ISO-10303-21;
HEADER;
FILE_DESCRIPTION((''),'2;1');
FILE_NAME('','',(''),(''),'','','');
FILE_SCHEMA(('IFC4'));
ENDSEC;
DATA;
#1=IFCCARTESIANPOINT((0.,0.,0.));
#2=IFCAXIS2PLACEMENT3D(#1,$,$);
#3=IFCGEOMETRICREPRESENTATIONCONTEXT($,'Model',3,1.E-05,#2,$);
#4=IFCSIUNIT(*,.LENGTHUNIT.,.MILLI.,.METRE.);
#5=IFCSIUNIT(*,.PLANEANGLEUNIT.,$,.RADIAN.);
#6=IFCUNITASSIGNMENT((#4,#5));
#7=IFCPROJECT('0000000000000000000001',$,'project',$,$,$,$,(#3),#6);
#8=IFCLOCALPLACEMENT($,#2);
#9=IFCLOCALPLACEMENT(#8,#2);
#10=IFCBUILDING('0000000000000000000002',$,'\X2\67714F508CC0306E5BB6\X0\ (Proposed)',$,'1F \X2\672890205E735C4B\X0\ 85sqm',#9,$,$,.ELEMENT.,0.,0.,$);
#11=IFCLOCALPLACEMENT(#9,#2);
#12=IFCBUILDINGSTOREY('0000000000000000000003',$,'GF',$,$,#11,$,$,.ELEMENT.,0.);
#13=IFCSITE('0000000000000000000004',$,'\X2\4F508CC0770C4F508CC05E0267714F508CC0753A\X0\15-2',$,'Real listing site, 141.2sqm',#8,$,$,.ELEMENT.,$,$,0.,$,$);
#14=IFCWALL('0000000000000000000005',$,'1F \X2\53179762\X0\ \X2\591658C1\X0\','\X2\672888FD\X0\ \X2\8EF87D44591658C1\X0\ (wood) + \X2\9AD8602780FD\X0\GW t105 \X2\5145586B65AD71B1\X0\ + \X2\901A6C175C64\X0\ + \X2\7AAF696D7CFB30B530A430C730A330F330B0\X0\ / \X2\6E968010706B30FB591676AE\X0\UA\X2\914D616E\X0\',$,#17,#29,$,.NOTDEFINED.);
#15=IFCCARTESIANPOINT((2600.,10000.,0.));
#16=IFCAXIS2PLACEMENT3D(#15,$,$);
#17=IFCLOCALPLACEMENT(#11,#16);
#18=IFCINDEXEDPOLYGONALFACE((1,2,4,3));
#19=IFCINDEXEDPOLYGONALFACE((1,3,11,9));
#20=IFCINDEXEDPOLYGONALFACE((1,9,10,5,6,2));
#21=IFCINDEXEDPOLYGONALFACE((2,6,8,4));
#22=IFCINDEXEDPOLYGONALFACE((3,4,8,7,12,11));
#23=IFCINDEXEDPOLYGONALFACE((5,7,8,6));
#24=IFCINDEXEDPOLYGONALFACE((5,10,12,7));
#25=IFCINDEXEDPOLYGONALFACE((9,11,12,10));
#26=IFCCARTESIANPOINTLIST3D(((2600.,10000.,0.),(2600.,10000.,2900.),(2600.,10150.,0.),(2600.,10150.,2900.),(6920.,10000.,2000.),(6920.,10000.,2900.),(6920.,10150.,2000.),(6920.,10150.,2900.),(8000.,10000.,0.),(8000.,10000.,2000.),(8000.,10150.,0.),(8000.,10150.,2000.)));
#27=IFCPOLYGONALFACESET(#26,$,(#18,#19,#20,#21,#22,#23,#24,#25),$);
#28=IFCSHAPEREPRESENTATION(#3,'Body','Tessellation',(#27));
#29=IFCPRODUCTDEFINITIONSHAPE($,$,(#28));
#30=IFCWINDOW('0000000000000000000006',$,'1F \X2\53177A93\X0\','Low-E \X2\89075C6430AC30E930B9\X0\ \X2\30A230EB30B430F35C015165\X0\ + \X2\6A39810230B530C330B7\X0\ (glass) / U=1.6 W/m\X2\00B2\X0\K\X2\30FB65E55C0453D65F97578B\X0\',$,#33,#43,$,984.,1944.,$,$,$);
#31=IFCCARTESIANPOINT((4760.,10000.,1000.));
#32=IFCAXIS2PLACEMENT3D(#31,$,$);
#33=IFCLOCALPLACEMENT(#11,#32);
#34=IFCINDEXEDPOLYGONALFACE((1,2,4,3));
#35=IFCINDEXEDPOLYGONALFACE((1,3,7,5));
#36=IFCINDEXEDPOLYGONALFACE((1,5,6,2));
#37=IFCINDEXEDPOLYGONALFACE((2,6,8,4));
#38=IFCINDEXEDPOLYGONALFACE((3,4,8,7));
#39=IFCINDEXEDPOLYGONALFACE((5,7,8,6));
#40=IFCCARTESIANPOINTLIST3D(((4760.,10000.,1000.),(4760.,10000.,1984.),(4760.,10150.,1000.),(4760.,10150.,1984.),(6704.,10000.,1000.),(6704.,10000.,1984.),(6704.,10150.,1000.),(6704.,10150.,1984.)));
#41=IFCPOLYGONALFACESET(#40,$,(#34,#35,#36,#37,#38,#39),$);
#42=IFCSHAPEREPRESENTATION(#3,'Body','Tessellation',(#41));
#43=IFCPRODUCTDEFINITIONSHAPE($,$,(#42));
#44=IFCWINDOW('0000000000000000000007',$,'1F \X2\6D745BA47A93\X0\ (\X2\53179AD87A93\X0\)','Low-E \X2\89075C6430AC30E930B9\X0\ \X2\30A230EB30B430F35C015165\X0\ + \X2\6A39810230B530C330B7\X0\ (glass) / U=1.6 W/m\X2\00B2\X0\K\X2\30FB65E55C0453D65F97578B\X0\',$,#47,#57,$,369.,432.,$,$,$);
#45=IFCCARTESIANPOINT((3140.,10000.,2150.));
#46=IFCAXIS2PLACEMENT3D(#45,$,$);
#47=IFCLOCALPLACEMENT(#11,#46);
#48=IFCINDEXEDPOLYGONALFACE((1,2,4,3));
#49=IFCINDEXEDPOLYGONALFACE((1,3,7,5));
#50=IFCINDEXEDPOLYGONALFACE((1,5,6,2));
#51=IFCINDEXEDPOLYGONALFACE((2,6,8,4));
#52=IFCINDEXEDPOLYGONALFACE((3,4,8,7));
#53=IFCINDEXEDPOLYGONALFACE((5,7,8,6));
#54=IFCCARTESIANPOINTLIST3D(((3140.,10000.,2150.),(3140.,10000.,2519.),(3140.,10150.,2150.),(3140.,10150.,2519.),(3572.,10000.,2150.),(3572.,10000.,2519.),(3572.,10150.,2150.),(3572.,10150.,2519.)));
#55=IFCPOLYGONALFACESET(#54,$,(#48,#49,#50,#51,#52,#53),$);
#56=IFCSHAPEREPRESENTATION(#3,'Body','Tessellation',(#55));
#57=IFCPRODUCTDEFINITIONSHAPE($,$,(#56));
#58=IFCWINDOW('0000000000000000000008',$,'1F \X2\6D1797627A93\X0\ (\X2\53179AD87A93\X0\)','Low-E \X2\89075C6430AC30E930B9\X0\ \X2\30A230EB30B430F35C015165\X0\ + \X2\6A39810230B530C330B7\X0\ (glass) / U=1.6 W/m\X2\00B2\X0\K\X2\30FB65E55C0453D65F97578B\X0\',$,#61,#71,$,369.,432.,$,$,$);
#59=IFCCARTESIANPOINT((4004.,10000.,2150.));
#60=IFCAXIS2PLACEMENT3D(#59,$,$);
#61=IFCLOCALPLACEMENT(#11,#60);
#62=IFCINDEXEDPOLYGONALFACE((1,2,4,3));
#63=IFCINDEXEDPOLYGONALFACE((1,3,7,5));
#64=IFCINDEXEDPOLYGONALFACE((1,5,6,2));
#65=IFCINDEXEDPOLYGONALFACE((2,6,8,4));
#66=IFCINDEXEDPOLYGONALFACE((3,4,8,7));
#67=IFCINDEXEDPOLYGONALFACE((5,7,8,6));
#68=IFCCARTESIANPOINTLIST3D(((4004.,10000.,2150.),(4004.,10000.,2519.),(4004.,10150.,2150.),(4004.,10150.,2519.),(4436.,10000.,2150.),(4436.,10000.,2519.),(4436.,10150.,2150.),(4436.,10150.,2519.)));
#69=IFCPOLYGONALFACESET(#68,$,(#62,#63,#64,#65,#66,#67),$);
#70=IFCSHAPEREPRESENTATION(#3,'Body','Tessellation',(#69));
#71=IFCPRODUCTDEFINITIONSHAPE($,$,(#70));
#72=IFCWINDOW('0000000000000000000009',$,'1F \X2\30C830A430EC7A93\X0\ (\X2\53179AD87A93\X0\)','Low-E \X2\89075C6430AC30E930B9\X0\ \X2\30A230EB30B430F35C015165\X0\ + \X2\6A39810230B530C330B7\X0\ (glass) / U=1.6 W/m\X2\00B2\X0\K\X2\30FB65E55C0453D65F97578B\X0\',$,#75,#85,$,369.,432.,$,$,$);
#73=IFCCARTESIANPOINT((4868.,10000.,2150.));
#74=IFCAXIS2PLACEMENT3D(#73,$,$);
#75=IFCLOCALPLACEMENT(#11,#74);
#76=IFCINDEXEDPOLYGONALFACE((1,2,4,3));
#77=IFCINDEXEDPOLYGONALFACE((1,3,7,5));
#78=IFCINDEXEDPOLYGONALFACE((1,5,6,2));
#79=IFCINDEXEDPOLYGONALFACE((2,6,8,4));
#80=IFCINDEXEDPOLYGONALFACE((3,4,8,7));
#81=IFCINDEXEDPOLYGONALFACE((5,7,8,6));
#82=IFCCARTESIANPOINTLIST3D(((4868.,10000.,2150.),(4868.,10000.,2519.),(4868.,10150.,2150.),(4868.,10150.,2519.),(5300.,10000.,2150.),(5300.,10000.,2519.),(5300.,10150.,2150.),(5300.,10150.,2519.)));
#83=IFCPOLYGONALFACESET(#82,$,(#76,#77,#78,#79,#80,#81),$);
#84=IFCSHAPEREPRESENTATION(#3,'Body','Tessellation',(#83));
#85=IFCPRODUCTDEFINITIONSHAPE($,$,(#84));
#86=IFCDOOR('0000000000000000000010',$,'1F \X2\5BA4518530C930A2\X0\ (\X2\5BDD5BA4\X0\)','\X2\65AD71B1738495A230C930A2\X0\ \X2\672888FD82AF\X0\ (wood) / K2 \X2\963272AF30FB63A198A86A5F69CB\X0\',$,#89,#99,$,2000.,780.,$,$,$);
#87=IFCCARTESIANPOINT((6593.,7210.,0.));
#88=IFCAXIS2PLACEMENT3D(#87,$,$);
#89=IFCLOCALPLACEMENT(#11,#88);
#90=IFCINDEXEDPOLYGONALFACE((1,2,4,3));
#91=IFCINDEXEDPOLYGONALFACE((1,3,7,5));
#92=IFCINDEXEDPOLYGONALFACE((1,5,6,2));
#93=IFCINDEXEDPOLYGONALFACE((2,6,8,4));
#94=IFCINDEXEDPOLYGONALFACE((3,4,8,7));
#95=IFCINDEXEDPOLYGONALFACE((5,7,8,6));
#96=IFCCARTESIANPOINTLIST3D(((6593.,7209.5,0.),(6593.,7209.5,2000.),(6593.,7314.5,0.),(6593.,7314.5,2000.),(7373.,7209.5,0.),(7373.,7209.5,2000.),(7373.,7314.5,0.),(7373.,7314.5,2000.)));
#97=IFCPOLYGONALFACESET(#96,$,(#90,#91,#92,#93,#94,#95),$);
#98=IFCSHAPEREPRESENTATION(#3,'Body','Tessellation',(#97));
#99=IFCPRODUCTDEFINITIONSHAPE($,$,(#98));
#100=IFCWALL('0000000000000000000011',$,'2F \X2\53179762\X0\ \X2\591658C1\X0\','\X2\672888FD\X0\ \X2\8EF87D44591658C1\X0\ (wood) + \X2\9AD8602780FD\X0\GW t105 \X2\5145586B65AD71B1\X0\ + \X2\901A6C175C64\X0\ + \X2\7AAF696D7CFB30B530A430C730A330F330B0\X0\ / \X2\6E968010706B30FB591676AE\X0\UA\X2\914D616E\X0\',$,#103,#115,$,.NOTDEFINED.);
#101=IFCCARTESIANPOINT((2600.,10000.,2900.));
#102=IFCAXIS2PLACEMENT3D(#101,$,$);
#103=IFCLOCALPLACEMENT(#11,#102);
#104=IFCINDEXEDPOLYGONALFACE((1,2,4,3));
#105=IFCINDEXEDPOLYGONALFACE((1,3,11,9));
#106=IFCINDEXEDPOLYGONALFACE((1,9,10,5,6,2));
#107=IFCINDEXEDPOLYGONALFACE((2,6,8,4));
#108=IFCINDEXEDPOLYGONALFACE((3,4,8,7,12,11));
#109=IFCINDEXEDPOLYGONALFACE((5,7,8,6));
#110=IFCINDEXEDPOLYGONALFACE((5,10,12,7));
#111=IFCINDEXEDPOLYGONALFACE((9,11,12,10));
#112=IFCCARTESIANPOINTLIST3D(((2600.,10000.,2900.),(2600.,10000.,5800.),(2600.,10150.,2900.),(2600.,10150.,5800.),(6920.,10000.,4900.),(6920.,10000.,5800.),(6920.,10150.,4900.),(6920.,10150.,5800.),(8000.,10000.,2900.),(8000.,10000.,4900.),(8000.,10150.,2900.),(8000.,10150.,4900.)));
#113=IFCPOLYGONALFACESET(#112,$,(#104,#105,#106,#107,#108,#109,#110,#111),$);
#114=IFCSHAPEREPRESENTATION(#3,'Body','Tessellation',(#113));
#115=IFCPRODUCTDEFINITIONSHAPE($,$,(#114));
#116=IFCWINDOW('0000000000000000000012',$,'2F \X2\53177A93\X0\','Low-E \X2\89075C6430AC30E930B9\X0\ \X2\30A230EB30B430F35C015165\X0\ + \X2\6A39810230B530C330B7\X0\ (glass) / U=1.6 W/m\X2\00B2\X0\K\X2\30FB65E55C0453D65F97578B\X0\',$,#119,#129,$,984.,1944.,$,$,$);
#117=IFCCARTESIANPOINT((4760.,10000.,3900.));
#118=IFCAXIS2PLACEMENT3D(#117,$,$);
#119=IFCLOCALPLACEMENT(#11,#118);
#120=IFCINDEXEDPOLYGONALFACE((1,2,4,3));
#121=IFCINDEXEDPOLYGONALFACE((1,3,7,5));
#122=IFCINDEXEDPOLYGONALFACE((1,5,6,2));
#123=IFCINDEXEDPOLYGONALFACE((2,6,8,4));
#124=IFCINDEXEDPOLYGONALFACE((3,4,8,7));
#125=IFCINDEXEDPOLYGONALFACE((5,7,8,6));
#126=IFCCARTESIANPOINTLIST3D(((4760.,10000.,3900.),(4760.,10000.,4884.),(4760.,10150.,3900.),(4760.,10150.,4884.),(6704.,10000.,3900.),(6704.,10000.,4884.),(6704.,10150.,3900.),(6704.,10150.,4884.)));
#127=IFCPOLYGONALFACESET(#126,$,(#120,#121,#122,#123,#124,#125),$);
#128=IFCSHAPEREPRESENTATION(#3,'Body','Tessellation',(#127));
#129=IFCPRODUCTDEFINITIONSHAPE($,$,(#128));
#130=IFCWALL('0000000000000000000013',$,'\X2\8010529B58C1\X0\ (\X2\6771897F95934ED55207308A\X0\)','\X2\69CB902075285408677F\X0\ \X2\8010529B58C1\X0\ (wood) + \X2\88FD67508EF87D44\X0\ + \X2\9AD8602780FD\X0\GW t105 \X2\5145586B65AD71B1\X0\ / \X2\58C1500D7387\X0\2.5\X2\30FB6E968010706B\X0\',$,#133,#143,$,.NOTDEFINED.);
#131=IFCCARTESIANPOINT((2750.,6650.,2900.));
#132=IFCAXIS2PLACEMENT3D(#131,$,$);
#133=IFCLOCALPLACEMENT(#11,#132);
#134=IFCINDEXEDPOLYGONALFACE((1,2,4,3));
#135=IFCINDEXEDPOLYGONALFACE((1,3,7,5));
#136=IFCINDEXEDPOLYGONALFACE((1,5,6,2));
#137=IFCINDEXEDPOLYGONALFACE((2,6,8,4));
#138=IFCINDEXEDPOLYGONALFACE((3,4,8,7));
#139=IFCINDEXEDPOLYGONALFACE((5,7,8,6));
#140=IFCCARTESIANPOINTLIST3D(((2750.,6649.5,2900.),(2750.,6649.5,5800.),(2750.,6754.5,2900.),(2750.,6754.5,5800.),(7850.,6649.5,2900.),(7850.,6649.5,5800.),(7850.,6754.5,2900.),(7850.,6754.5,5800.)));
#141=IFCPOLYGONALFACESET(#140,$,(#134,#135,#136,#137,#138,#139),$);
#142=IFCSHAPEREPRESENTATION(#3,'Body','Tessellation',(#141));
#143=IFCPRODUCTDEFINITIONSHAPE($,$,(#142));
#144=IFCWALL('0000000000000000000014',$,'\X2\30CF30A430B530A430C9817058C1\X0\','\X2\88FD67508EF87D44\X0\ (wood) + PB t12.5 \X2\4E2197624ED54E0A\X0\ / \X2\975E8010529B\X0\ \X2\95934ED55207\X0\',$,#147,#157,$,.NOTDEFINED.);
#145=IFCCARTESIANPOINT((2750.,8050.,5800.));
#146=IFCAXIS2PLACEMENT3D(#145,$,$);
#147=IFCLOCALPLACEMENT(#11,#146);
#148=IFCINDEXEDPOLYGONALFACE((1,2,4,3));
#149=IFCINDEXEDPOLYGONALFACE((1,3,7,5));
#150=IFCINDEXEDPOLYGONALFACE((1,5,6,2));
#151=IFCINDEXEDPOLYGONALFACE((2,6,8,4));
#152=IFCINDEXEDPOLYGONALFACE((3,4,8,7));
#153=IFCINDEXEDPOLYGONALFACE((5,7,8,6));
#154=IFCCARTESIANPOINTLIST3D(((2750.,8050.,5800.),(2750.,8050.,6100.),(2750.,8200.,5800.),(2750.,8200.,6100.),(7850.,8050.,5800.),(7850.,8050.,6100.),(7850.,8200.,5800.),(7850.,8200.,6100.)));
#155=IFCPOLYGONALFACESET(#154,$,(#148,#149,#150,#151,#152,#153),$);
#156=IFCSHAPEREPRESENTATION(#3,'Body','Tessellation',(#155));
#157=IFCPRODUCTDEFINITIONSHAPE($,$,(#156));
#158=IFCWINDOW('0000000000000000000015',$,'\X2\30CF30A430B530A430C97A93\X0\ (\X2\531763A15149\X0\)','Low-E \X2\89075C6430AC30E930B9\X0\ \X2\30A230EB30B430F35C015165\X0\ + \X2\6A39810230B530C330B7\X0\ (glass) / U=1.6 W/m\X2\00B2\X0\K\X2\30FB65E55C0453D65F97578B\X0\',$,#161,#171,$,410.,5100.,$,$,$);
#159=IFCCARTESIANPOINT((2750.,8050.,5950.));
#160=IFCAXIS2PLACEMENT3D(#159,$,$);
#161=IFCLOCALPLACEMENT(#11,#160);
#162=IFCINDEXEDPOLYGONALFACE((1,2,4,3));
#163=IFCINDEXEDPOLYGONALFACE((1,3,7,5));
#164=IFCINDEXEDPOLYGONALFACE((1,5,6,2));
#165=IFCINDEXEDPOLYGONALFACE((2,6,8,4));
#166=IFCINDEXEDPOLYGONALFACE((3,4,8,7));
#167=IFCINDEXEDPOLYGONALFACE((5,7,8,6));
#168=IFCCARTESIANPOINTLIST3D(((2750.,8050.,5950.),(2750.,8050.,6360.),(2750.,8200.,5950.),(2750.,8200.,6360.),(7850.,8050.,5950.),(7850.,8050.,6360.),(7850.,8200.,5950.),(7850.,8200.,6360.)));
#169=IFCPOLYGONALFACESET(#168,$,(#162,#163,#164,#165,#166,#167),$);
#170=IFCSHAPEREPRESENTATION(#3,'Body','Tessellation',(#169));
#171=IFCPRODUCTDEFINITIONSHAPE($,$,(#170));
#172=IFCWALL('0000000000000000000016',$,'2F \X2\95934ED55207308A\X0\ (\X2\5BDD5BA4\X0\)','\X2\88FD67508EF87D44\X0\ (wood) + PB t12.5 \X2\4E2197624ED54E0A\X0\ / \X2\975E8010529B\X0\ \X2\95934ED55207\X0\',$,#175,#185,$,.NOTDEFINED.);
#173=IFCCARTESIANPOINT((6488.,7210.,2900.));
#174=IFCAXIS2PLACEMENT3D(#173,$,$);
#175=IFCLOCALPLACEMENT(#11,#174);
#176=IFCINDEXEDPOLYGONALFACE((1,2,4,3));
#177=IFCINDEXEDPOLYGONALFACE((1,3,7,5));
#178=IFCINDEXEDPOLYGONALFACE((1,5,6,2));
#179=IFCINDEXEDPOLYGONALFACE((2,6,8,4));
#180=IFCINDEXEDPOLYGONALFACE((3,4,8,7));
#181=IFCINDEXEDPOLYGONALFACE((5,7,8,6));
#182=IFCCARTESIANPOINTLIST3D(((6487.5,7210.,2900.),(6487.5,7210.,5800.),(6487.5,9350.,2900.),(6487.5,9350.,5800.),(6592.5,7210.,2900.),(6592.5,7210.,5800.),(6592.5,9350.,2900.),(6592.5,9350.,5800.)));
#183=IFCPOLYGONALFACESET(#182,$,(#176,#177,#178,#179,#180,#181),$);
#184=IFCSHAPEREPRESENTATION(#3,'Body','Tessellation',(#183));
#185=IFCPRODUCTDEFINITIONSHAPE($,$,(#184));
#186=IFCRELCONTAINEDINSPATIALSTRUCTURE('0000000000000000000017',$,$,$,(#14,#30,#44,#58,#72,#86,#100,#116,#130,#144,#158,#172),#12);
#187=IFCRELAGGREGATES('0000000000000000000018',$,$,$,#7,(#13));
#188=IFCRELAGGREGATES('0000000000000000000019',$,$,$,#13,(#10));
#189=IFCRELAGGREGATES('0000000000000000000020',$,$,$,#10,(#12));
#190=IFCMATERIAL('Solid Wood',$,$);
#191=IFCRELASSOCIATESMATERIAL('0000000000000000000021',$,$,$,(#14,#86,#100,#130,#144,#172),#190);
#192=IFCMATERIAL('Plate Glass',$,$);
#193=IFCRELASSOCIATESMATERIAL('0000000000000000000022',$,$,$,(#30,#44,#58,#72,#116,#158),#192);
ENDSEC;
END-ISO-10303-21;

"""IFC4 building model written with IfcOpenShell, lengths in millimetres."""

from ifc_helpers import new_model, si_unit, frame, frame_2d, origin, place, context, project, spatial, rectangle, extrude, material, element, fill, save


model = new_model("IFC4")

# Units and contexts
model_context = context("Model", 3, precision=1e-05, world=origin())
ifc_project = project(units=[si_unit("LENGTHUNIT", "METRE", prefix="MILLI"), si_unit("PLANEANGLEUNIT", "RADIAN")], contexts=[model_context])

# Site, building, storey
site_placement = place(None, origin())
site = spatial("IfcSite", under=ifc_project, at=site_placement, Name="佐賀県佐賀市東佐賀町15-2", ObjectType="Real listing site, 141.2sqm", CompositionType="ELEMENT", RefElevation=0.0)
building_placement = place(site_placement, origin())
building = spatial("IfcBuilding", under=site, at=building_placement, Name="東佐賀の家 (Proposed)", ObjectType="1F 木造平屋 85sqm", CompositionType="ELEMENT", ElevationOfRefHeight=0.0, ElevationOfTerrain=0.0)
storey_placement = place(building_placement, origin())
storey = spatial("IfcBuildingStorey", under=building, at=storey_placement, Name="GF", CompositionType="ELEMENT", Elevation=0.0)

# Wall, openings, windows
ifc_material_1 = material(Name="Solid Wood")
wall_1_placement = place(storey_placement, frame((2600.0, 10000.0, 0.0)))
wall_1 = element("IfcWall", 1, at=wall_1_placement, inside=storey, material=ifc_material_1, Name="1F 北面 外壁", Description="木製 軸組外壁 (wood) + 高性能GW t105 充填断熱 + 通気層 + 窯業系サイディング / 準耐火・外皮UA配慮", PredefinedType="NOTDEFINED", context=model_context, shape_type="SweptSolid", body=[
    extrude(rectangle(XDim=5400.0, YDim=150.0, at=frame_2d((2700.0, 75.0))), frame((2600.0, 10000.0, 0.0)), (0.0, 0.0, 1.0), 2900.0),
])
opening_1_placement = place(storey_placement, frame((4760.0, 10000.0, 1000.0)))
opening_1 = element("IfcOpeningElement", 2, at=opening_1_placement, cuts=wall_1, PredefinedType="NOTDEFINED", context=model_context, shape_type="SweptSolid", body=[
    extrude(rectangle(XDim=1944.0, YDim=150.0, at=frame_2d((972.0, 75.0))), frame((4760.0, 10000.0, 1000.0)), (0.0, 0.0, 1.0), 984.0),
])
opening_2_placement = place(storey_placement, frame((3140.0, 10000.0, 2150.0)))
opening_2 = element("IfcOpeningElement", 3, at=opening_2_placement, cuts=wall_1, PredefinedType="NOTDEFINED", context=model_context, shape_type="SweptSolid", body=[
    extrude(rectangle(XDim=432.0, YDim=150.0, at=frame_2d((216.0, 75.0))), frame((3140.0, 10000.0, 2150.0)), (0.0, 0.0, 1.0), 369.0),
])
opening_3_placement = place(storey_placement, frame((4004.0, 10000.0, 2150.0)))
opening_3 = element("IfcOpeningElement", 4, at=opening_3_placement, cuts=wall_1, PredefinedType="NOTDEFINED", context=model_context, shape_type="SweptSolid", body=[
    extrude(rectangle(XDim=432.0, YDim=150.0, at=frame_2d((216.0, 75.0))), frame((4004.0, 10000.0, 2150.0)), (0.0, 0.0, 1.0), 369.0),
])
opening_4_placement = place(storey_placement, frame((4868.0, 10000.0, 2150.0)))
opening_4 = element("IfcOpeningElement", 5, at=opening_4_placement, cuts=wall_1, PredefinedType="NOTDEFINED", context=model_context, shape_type="SweptSolid", body=[
    extrude(rectangle(XDim=432.0, YDim=150.0, at=frame_2d((216.0, 75.0))), frame((4868.0, 10000.0, 2150.0)), (0.0, 0.0, 1.0), 369.0),
])
ifc_material_2 = material(Name="Plate Glass")
window_1_placement = place(storey_placement, frame((4760.0, 10000.0, 1000.0)))
window_1 = element("IfcWindow", 6, at=window_1_placement, inside=storey, material=ifc_material_2, Name="1F 北窓", Description="Low-E 複層ガラス アルゴン封入 + 樹脂サッシ (glass) / U=1.6 W/m²K・日射取得型", OverallHeight=984.0, OverallWidth=1944.0, context=model_context, shape_type="SweptSolid", body=[
    extrude(rectangle(XDim=1944.0, YDim=150.0, at=frame_2d((972.0, 75.0))), frame((4760.0, 10000.0, 1000.0)), (0.0, 0.0, 1.0), 984.0),
])
fill(opening_1, window_1)
window_2_placement = place(storey_placement, frame((3140.0, 10000.0, 2150.0)))
window_2 = element("IfcWindow", 7, at=window_2_placement, inside=storey, material=ifc_material_2, Name="1F 浴室窓 (北高窓)", Description="Low-E 複層ガラス アルゴン封入 + 樹脂サッシ (glass) / U=1.6 W/m²K・日射取得型", OverallHeight=369.0, OverallWidth=432.0, context=model_context, shape_type="SweptSolid", body=[
    extrude(rectangle(XDim=432.0, YDim=150.0, at=frame_2d((216.0, 75.0))), frame((3140.0, 10000.0, 2150.0)), (0.0, 0.0, 1.0), 369.0),
])
fill(opening_2, window_2)
window_3_placement = place(storey_placement, frame((4004.0, 10000.0, 2150.0)))
window_3 = element("IfcWindow", 8, at=window_3_placement, inside=storey, material=ifc_material_2, Name="1F 洗面窓 (北高窓)", Description="Low-E 複層ガラス アルゴン封入 + 樹脂サッシ (glass) / U=1.6 W/m²K・日射取得型", OverallHeight=369.0, OverallWidth=432.0, context=model_context, shape_type="SweptSolid", body=[
    extrude(rectangle(XDim=432.0, YDim=150.0, at=frame_2d((216.0, 75.0))), frame((4004.0, 10000.0, 2150.0)), (0.0, 0.0, 1.0), 369.0),
])
fill(opening_3, window_3)
window_4_placement = place(storey_placement, frame((4868.0, 10000.0, 2150.0)))
window_4 = element("IfcWindow", 9, at=window_4_placement, inside=storey, material=ifc_material_2, Name="1F トイレ窓 (北高窓)", Description="Low-E 複層ガラス アルゴン封入 + 樹脂サッシ (glass) / U=1.6 W/m²K・日射取得型", OverallHeight=369.0, OverallWidth=432.0, context=model_context, shape_type="SweptSolid", body=[
    extrude(rectangle(XDim=432.0, YDim=150.0, at=frame_2d((216.0, 75.0))), frame((4868.0, 10000.0, 2150.0)), (0.0, 0.0, 1.0), 369.0),
])
fill(opening_4, window_4)

# Door
door_1_placement = place(storey_placement, frame((6593.0, 7210.0, 0.0)))
element("IfcDoor", 10, at=door_1_placement, inside=storey, material=ifc_material_1, Name="1F 室内ドア (寝室)", Description="断熱玄関ドア 木製芯 (wood) / K2 防犯・採風機構", OverallHeight=2000.0, OverallWidth=780.0, context=model_context, shape_type="SweptSolid", body=[
    extrude(rectangle(XDim=780.0, YDim=105.0, at=frame_2d((390.0, 52.0))), frame((6593.0, 7210.0, 0.0)), (0.0, 0.0, 1.0), 2000.0),
])

# Wall, opening, window
wall_2_placement = place(storey_placement, frame((2600.0, 10000.0, 2900.0)))
wall_2 = element("IfcWall", 11, at=wall_2_placement, inside=storey, material=ifc_material_1, Name="2F 北面 外壁", Description="木製 軸組外壁 (wood) + 高性能GW t105 充填断熱 + 通気層 + 窯業系サイディング / 準耐火・外皮UA配慮", PredefinedType="NOTDEFINED", context=model_context, shape_type="SweptSolid", body=[
    extrude(rectangle(XDim=5400.0, YDim=150.0, at=frame_2d((2700.0, 75.0))), frame((2600.0, 10000.0, 2900.0)), (0.0, 0.0, 1.0), 2900.0),
])
opening_5_placement = place(storey_placement, frame((4760.0, 10000.0, 3900.0)))
opening_5 = element("IfcOpeningElement", 12, at=opening_5_placement, cuts=wall_2, PredefinedType="NOTDEFINED", context=model_context, shape_type="SweptSolid", body=[
    extrude(rectangle(XDim=1944.0, YDim=150.0, at=frame_2d((972.0, 75.0))), frame((4760.0, 10000.0, 3900.0)), (0.0, 0.0, 1.0), 984.0),
])
window_5_placement = place(storey_placement, frame((4760.0, 10000.0, 3900.0)))
window_5 = element("IfcWindow", 13, at=window_5_placement, inside=storey, material=ifc_material_2, Name="2F 北窓", Description="Low-E 複層ガラス アルゴン封入 + 樹脂サッシ (glass) / U=1.6 W/m²K・日射取得型", OverallHeight=984.0, OverallWidth=1944.0, context=model_context, shape_type="SweptSolid", body=[
    extrude(rectangle(XDim=1944.0, YDim=150.0, at=frame_2d((972.0, 75.0))), frame((4760.0, 10000.0, 3900.0)), (0.0, 0.0, 1.0), 984.0),
])
fill(opening_5, window_5)

# Wall
wall_3_placement = place(storey_placement, frame((2750.0, 6650.0, 2900.0)))
element("IfcWall", 14, at=wall_3_placement, inside=storey, material=ifc_material_1, Name="耐力壁 (東西間仕切り)", Description="構造用合板 耐力壁 (wood) + 製材軸組 + 高性能GW t105 充填断熱 / 壁倍率2.5・準耐火", PredefinedType="NOTDEFINED", context=model_context, shape_type="SweptSolid", body=[
    extrude(rectangle(XDim=5100.0, YDim=105.0, at=frame_2d((2550.0, 52.0))), frame((2750.0, 6650.0, 2900.0)), (0.0, 0.0, 1.0), 2900.0),
])

# Wall, opening, window
wall_4_placement = place(storey_placement, frame((2750.0, 8050.0, 5800.0)))
wall_4 = element("IfcWall", 15, at=wall_4_placement, inside=storey, material=ifc_material_1, Name="ハイサイド腰壁", Description="製材軸組 (wood) + PB t12.5 両面仕上 / 非耐力 間仕切", PredefinedType="NOTDEFINED", context=model_context, shape_type="SweptSolid", body=[
    extrude(rectangle(XDim=5100.0, YDim=150.0, at=frame_2d((2550.0, 75.0))), frame((2750.0, 8050.0, 5800.0)), (0.0, 0.0, 1.0), 700.0),
])
opening_6_placement = place(storey_placement, frame((2750.0, 8050.0, 5950.0)))
opening_6 = element("IfcOpeningElement", 16, at=opening_6_placement, cuts=wall_4, PredefinedType="NOTDEFINED", context=model_context, shape_type="SweptSolid", body=[
    extrude(rectangle(XDim=5100.0, YDim=150.0, at=frame_2d((2550.0, 75.0))), frame((2750.0, 8050.0, 5950.0)), (0.0, 0.0, 1.0), 410.0),
])
window_6_placement = place(storey_placement, frame((2750.0, 8050.0, 5950.0)))
window_6 = element("IfcWindow", 17, at=window_6_placement, inside=storey, material=ifc_material_2, Name="ハイサイド窓 (北採光)", Description="Low-E 複層ガラス アルゴン封入 + 樹脂サッシ (glass) / U=1.6 W/m²K・日射取得型", OverallHeight=410.0, OverallWidth=5100.0, context=model_context, shape_type="SweptSolid", body=[
    extrude(rectangle(XDim=5100.0, YDim=150.0, at=frame_2d((2550.0, 75.0))), frame((2750.0, 8050.0, 5950.0)), (0.0, 0.0, 1.0), 410.0),
])
fill(opening_6, window_6)

# Wall
wall_5_placement = place(storey_placement, frame((6488.0, 7210.0, 2900.0)))
element("IfcWall", 18, at=wall_5_placement, inside=storey, material=ifc_material_1, Name="2F 間仕切り (寝室)", Description="製材軸組 (wood) + PB t12.5 両面仕上 / 非耐力 間仕切", PredefinedType="NOTDEFINED", context=model_context, shape_type="SweptSolid", body=[
    extrude(rectangle(XDim=105.0, YDim=2140.0, at=frame_2d((52.0, 1070.0))), frame((6488.0, 7210.0, 2900.0)), (0.0, 0.0, 1.0), 2900.0),
])

save(model, "model.ifc")
